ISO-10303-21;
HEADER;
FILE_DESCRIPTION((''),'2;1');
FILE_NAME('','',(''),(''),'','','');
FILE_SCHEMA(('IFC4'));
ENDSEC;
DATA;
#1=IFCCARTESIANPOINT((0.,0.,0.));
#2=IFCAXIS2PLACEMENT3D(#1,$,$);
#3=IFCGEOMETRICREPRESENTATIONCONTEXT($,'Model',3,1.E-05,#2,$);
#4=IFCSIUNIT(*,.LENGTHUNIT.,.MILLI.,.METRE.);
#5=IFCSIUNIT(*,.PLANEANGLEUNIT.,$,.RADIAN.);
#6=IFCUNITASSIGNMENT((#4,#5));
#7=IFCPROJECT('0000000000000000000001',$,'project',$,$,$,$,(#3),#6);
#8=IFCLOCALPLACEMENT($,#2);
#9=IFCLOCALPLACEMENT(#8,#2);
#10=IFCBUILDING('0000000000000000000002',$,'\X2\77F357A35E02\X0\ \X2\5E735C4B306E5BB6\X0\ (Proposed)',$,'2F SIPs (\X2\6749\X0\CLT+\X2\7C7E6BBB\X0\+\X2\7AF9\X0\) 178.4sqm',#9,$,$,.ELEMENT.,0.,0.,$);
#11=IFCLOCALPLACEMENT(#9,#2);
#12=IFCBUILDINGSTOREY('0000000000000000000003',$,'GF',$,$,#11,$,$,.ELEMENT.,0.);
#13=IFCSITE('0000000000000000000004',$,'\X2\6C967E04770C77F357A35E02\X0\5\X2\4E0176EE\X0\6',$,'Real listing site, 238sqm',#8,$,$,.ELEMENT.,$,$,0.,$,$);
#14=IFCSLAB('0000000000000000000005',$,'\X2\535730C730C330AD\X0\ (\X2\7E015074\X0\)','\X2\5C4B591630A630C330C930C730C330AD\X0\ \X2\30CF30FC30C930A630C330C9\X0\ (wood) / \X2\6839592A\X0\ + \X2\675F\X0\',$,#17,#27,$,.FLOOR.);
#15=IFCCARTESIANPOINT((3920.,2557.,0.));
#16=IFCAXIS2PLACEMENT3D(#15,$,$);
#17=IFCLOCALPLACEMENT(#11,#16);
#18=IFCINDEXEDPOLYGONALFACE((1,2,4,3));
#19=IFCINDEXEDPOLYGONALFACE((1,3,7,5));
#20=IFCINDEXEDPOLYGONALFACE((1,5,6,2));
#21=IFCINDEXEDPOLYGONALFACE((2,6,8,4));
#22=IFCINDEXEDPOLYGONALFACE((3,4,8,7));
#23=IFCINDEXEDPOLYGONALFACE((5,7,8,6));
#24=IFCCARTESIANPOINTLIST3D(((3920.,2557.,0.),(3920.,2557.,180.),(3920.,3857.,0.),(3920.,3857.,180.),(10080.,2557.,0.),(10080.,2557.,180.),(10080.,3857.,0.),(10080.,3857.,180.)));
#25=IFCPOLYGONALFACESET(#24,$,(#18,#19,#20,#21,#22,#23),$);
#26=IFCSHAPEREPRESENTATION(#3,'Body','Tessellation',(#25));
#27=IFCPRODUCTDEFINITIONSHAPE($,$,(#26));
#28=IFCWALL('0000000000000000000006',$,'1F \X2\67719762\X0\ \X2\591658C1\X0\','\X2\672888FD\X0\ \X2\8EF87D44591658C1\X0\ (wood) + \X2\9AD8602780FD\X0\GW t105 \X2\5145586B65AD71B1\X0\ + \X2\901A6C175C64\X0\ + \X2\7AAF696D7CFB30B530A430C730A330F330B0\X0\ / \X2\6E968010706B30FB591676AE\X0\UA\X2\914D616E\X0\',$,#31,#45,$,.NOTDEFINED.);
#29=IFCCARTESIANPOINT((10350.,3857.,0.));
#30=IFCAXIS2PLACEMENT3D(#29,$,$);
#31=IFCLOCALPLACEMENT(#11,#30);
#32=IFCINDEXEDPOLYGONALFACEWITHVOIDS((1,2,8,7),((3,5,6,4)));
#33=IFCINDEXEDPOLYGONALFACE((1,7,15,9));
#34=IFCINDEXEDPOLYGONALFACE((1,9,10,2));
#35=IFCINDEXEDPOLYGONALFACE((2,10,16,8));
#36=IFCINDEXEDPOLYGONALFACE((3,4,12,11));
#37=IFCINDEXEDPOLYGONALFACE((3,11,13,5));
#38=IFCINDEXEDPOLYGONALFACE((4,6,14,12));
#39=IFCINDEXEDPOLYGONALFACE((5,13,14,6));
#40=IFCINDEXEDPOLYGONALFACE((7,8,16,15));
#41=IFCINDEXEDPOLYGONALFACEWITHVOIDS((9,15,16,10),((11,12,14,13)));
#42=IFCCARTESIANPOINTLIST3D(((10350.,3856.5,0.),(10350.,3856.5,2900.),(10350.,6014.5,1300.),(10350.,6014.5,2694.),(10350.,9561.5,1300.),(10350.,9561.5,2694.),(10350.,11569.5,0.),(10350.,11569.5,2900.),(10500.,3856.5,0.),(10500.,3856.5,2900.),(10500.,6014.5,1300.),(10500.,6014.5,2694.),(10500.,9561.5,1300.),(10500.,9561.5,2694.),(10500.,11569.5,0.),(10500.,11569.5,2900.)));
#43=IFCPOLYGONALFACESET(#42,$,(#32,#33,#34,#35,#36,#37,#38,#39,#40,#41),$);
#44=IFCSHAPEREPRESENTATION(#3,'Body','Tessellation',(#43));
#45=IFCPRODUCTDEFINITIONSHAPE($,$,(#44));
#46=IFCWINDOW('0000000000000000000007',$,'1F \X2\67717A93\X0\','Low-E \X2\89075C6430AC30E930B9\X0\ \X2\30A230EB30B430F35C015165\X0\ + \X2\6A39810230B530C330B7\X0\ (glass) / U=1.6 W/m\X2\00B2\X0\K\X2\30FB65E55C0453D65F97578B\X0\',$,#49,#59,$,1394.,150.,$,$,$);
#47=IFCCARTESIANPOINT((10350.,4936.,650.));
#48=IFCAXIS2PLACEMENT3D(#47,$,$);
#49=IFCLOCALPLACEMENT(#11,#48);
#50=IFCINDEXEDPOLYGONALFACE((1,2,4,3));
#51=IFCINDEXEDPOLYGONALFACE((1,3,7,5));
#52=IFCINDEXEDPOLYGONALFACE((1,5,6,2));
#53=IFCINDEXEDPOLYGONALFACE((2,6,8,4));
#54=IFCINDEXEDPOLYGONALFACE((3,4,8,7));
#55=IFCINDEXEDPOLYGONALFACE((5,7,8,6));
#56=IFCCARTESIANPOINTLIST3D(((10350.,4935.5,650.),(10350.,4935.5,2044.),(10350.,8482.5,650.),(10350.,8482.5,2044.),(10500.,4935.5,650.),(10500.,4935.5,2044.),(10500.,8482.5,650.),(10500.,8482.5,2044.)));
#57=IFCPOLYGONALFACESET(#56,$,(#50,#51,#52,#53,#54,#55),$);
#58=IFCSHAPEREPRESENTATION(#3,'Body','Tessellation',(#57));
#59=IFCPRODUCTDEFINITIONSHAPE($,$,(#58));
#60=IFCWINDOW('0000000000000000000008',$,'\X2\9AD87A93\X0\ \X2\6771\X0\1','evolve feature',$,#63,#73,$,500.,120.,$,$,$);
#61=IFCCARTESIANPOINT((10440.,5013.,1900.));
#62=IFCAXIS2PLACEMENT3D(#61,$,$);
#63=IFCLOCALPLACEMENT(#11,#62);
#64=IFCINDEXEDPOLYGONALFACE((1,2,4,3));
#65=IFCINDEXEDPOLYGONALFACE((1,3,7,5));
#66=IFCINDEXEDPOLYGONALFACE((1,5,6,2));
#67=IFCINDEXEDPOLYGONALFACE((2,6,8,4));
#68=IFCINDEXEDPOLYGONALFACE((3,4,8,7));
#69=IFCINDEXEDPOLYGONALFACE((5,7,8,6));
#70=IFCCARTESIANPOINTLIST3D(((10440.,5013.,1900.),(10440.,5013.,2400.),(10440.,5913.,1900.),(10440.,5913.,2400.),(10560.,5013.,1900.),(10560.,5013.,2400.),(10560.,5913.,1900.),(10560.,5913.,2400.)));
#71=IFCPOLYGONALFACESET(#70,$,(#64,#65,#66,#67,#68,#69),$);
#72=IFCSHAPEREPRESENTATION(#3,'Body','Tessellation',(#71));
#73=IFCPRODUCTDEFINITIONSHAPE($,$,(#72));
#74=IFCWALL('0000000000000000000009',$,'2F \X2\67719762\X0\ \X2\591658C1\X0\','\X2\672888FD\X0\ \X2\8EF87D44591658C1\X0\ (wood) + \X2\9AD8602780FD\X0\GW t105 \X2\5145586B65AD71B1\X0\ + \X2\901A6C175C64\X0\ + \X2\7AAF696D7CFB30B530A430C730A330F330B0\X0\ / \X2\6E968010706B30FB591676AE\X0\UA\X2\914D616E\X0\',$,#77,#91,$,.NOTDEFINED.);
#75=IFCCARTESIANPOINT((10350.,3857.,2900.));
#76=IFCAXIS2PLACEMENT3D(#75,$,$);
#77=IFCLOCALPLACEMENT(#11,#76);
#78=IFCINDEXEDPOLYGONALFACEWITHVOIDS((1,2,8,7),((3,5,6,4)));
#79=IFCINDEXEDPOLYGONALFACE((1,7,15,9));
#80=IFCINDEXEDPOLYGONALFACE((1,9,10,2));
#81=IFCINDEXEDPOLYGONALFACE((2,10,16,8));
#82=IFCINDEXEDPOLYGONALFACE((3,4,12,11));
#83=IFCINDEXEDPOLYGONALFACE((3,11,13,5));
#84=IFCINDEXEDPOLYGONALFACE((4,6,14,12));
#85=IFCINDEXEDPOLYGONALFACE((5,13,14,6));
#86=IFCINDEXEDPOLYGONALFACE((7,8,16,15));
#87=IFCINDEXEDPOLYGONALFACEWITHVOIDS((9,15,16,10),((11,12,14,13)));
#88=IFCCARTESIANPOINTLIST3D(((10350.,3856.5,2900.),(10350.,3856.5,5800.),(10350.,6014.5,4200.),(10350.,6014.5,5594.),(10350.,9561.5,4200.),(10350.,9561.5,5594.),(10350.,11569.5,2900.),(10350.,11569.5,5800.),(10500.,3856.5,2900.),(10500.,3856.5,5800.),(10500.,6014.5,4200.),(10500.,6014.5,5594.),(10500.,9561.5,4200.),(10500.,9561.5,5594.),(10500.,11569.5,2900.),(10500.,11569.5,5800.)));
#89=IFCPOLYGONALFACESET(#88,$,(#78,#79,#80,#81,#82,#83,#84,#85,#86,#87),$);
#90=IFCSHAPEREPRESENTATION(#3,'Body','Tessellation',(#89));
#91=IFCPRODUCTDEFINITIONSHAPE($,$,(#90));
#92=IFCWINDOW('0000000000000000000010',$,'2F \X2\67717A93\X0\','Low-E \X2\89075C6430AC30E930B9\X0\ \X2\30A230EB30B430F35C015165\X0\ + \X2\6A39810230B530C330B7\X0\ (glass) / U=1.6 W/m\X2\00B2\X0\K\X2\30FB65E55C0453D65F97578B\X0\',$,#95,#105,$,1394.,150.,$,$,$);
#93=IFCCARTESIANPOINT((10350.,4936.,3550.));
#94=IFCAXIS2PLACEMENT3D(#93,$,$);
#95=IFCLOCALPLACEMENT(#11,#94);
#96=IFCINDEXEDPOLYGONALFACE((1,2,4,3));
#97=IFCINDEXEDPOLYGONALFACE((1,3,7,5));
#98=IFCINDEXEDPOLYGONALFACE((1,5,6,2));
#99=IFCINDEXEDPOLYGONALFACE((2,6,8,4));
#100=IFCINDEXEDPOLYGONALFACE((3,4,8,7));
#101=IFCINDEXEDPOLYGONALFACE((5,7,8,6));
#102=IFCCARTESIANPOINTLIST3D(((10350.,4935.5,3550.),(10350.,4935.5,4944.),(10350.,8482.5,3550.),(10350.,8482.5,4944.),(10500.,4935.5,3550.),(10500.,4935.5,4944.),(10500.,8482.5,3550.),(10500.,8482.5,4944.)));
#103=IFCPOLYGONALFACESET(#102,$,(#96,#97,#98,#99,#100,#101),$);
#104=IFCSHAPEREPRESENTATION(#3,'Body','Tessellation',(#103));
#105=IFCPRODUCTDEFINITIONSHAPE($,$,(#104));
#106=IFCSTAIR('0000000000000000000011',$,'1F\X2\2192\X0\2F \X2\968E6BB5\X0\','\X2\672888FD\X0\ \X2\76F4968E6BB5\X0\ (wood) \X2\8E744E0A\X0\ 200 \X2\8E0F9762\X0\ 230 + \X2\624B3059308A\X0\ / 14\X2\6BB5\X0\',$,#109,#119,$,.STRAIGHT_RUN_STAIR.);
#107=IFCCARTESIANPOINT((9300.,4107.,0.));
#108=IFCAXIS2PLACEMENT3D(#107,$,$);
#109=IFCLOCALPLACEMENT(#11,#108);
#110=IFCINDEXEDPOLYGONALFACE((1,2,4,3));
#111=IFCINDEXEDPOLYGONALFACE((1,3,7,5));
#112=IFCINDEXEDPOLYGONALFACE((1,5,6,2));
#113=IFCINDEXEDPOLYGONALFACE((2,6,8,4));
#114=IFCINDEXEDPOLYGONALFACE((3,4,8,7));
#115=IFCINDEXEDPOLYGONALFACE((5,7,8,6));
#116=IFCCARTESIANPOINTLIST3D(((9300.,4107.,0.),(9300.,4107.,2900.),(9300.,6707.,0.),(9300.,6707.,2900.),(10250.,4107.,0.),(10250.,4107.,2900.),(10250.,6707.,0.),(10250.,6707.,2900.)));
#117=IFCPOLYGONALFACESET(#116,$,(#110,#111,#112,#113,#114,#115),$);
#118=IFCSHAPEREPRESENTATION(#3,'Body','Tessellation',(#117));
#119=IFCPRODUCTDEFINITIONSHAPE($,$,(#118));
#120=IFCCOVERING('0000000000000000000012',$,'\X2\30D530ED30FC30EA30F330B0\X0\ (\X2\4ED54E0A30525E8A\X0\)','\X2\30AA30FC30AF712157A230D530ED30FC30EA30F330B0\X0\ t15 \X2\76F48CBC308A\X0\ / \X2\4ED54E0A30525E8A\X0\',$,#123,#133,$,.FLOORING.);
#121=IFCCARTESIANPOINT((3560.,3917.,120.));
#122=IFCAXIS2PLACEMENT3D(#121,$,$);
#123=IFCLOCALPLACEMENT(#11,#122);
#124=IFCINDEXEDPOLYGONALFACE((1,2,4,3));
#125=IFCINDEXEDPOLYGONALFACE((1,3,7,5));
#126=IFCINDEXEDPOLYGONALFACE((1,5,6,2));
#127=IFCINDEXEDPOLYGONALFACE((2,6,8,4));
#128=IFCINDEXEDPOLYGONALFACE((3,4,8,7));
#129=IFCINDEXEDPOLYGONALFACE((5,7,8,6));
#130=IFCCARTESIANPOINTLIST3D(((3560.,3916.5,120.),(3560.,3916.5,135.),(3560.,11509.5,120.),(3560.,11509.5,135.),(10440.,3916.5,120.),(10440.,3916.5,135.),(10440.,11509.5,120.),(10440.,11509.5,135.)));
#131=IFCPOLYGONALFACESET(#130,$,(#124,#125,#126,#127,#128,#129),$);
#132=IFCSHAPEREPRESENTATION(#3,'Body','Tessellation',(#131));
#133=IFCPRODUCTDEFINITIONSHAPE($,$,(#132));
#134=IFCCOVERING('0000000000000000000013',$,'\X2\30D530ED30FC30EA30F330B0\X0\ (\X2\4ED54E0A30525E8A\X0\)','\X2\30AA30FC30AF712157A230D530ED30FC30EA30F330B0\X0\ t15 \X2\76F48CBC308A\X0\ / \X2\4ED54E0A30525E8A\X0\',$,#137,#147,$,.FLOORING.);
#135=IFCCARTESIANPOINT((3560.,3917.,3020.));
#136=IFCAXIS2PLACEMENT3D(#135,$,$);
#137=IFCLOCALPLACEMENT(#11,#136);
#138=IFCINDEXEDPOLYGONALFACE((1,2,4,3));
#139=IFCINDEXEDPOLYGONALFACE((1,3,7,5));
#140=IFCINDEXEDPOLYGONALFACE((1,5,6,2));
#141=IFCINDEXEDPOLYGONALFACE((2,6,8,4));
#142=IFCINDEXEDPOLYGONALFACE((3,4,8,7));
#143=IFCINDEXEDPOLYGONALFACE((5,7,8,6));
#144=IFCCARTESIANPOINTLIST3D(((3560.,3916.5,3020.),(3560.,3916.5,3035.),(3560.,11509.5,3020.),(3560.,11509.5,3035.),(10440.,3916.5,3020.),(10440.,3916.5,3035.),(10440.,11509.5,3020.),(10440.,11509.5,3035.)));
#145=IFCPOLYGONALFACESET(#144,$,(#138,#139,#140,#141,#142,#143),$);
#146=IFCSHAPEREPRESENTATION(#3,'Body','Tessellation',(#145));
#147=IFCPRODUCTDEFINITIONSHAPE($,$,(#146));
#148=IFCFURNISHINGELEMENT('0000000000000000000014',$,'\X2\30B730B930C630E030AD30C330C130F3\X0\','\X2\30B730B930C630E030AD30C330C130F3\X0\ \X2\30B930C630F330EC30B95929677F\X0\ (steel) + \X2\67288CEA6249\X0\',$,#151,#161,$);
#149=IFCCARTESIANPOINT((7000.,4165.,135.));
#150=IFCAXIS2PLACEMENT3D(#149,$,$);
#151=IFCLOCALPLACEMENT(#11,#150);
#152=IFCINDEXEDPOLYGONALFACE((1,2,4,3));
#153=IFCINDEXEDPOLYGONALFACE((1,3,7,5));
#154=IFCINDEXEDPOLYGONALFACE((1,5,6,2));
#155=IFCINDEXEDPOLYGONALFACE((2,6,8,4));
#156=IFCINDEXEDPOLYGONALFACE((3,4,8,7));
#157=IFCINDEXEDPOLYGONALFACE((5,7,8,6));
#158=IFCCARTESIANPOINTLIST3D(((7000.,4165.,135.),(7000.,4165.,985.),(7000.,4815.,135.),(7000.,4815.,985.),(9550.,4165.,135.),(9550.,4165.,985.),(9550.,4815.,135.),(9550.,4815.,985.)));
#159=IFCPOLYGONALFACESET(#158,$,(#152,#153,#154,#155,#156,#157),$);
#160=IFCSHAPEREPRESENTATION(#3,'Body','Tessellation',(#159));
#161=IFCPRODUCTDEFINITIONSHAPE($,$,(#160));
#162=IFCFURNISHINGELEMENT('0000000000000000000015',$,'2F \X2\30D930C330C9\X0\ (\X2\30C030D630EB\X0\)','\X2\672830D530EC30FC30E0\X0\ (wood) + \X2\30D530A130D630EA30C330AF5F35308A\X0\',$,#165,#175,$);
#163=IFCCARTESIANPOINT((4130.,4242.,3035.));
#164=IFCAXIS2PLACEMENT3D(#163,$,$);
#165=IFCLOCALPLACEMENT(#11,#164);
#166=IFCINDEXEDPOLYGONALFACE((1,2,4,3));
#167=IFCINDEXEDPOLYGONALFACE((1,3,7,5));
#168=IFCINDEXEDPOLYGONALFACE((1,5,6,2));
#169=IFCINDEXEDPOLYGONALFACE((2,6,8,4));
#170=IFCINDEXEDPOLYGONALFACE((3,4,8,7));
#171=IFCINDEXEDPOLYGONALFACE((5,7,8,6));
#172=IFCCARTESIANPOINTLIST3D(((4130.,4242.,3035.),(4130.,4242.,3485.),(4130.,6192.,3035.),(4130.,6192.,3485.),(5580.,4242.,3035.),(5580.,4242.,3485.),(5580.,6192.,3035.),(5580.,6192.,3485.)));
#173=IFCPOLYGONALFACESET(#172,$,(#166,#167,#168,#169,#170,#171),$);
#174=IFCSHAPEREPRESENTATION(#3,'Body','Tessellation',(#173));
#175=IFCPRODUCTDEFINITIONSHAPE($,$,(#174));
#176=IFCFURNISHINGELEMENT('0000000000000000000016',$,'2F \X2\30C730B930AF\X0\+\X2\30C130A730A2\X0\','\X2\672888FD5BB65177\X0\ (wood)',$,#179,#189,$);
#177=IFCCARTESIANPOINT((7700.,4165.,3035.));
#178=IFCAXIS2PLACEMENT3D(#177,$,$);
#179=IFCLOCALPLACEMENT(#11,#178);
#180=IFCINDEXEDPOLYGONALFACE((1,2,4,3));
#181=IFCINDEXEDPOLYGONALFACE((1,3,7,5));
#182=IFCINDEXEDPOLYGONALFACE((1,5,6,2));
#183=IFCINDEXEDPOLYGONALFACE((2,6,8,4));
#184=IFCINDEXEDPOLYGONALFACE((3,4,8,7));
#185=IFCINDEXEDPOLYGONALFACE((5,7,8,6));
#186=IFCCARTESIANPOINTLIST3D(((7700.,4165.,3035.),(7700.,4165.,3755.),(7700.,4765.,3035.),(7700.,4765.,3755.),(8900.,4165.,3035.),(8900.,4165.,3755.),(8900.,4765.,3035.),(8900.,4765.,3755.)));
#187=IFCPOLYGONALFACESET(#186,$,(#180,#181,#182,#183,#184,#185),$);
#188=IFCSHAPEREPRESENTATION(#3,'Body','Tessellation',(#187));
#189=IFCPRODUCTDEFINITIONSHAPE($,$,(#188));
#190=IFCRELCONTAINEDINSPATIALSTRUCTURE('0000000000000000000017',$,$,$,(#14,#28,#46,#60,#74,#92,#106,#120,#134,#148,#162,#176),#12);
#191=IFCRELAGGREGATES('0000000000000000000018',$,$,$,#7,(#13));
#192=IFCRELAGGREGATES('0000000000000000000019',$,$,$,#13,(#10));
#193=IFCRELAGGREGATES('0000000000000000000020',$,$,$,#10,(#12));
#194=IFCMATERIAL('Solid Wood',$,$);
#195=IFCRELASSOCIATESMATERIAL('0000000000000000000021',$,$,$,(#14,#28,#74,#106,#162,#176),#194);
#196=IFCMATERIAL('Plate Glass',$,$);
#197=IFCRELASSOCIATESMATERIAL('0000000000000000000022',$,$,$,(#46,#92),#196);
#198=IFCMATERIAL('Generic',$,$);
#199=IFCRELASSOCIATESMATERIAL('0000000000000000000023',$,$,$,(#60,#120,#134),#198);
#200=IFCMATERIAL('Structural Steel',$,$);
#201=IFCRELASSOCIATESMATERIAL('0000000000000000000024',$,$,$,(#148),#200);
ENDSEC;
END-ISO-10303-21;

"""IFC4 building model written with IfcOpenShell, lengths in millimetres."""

from ifc_helpers import new_model, si_unit, frame, frame_2d, origin, place, context, project, spatial, rectangle, extrude, material, element, fill, save


model = new_model("IFC4")

# Units and contexts
model_context = context("Model", 3, precision=1e-05, world=origin())
ifc_project = project(units=[si_unit("LENGTHUNIT", "METRE", prefix="MILLI"), si_unit("PLANEANGLEUNIT", "RADIAN")], contexts=[model_context])

# Site, building, storey
site_placement = place(None, origin())
site = spatial("IfcSite", under=ifc_project, at=site_placement, Name="沖縄県石垣市5丁目6", ObjectType="Real listing site, 238sqm", CompositionType="ELEMENT", RefElevation=0.0)
building_placement = place(site_placement, origin())
building = spatial("IfcBuilding", under=site, at=building_placement, Name="石垣市 平屋の家 (Proposed)", ObjectType="2F SIPs (杉CLT+籾殻+竹) 178.4sqm", CompositionType="ELEMENT", ElevationOfRefHeight=0.0, ElevationOfTerrain=0.0)
storey_placement = place(building_placement, origin())
storey = spatial("IfcBuildingStorey", under=building, at=storey_placement, Name="GF", CompositionType="ELEMENT", Elevation=0.0)

# Slab
ifc_material_1 = material(Name="Solid Wood")
slab_placement = place(storey_placement, frame((3920.0, 2557.0, 0.0)))
element("IfcSlab", 1, at=slab_placement, inside=storey, material=ifc_material_1, Name="南デッキ (縁側)", Description="屋外ウッドデッキ ハードウッド (wood) / 根太 + 束", PredefinedType="FLOOR", context=model_context, shape_type="SweptSolid", body=[
    extrude(rectangle(XDim=6160.0, YDim=1300.0, at=frame_2d((3080.0, 650.0))), frame((3920.0, 2557.0, 0.0)), (0.0, 0.0, 1.0), 180.0),
])

# Wall, openings, windows
wall_1_placement = place(storey_placement, frame((10350.0, 3857.0, 0.0)))
wall_1 = element("IfcWall", 2, at=wall_1_placement, inside=storey, material=ifc_material_1, Name="1F 東面 外壁", Description="木製 軸組外壁 (wood) + 高性能GW t105 充填断熱 + 通気層 + 窯業系サイディング / 準耐火・外皮UA配慮", PredefinedType="NOTDEFINED", context=model_context, shape_type="SweptSolid", body=[
    extrude(rectangle(XDim=150.0, YDim=7713.0, at=frame_2d((75.0, 3856.0))), frame((10350.0, 3857.0, 0.0)), (0.0, 0.0, 1.0), 2900.0),
])
opening_1_placement = place(storey_placement, frame((10350.0, 4936.0, 650.0)))
opening_1 = element("IfcOpeningElement", 3, at=opening_1_placement, cuts=wall_1, PredefinedType="NOTDEFINED", context=model_context, shape_type="SweptSolid", body=[
    extrude(rectangle(XDim=150.0, YDim=3547.0, at=frame_2d((75.0, 1773.0))), frame((10350.0, 4936.0, 650.0)), (0.0, 0.0, 1.0), 1394.0),
])
opening_2_placement = place(storey_placement, frame((10440.0, 5013.0, 1900.0)))
opening_2 = element("IfcOpeningElement", 4, at=opening_2_placement, cuts=wall_1, PredefinedType="NOTDEFINED", context=model_context, shape_type="SweptSolid", body=[
    extrude(rectangle(XDim=120.0, YDim=900.0, at=frame_2d((60.0, 450.0))), frame((10440.0, 5013.0, 1900.0)), (0.0, 0.0, 1.0), 500.0),
])
ifc_material_2 = material(Name="Plate Glass")
window_1_placement = place(storey_placement, frame((10350.0, 4936.0, 650.0)))
window_1 = element("IfcWindow", 5, at=window_1_placement, inside=storey, material=ifc_material_2, Name="1F 東窓", Description="Low-E 複層ガラス アルゴン封入 + 樹脂サッシ (glass) / U=1.6 W/m²K・日射取得型", OverallHeight=1394.0, OverallWidth=150.0, context=model_context, shape_type="SweptSolid", body=[
    extrude(rectangle(XDim=150.0, YDim=3547.0, at=frame_2d((75.0, 1773.0))), frame((10350.0, 4936.0, 650.0)), (0.0, 0.0, 1.0), 1394.0),
])
fill(opening_1, window_1)
ifc_material_3 = material(Name="Generic")
window_2_placement = place(storey_placement, frame((10440.0, 5013.0, 1900.0)))
window_2 = element("IfcWindow", 6, at=window_2_placement, inside=storey, material=ifc_material_3, Name="高窓 東1", Description="evolve feature", OverallHeight=500.0, OverallWidth=120.0, context=model_context, shape_type="SweptSolid", body=[
    extrude(rectangle(XDim=120.0, YDim=900.0, at=frame_2d((60.0, 450.0))), frame((10440.0, 5013.0, 1900.0)), (0.0, 0.0, 1.0), 500.0),
])
fill(opening_2, window_2)

# Wall, opening, window
wall_2_placement = place(storey_placement, frame((10350.0, 3857.0, 2900.0)))
wall_2 = element("IfcWall", 7, at=wall_2_placement, inside=storey, material=ifc_material_1, Name="2F 東面 外壁", Description="木製 軸組外壁 (wood) + 高性能GW t105 充填断熱 + 通気層 + 窯業系サイディング / 準耐火・外皮UA配慮", PredefinedType="NOTDEFINED", context=model_context, shape_type="SweptSolid", body=[
    extrude(rectangle(XDim=150.0, YDim=7713.0, at=frame_2d((75.0, 3856.0))), frame((10350.0, 3857.0, 2900.0)), (0.0, 0.0, 1.0), 2900.0),
])
opening_3_placement = place(storey_placement, frame((10350.0, 4936.0, 3550.0)))
opening_3 = element("IfcOpeningElement", 8, at=opening_3_placement, cuts=wall_2, PredefinedType="NOTDEFINED", context=model_context, shape_type="SweptSolid", body=[
    extrude(rectangle(XDim=150.0, YDim=3547.0, at=frame_2d((75.0, 1773.0))), frame((10350.0, 4936.0, 3550.0)), (0.0, 0.0, 1.0), 1394.0),
])
window_3_placement = place(storey_placement, frame((10350.0, 4936.0, 3550.0)))
window_3 = element("IfcWindow", 9, at=window_3_placement, inside=storey, material=ifc_material_2, Name="2F 東窓", Description="Low-E 複層ガラス アルゴン封入 + 樹脂サッシ (glass) / U=1.6 W/m²K・日射取得型", OverallHeight=1394.0, OverallWidth=150.0, context=model_context, shape_type="SweptSolid", body=[
    extrude(rectangle(XDim=150.0, YDim=3547.0, at=frame_2d((75.0, 1773.0))), frame((10350.0, 4936.0, 3550.0)), (0.0, 0.0, 1.0), 1394.0),
])
fill(opening_3, window_3)

# Stair
stair_placement = place(storey_placement, frame((9300.0, 4107.0, 0.0)))
element("IfcStair", 10, at=stair_placement, inside=storey, material=ifc_material_1, Name="1F→2F 階段", Description="木製 直階段 (wood) 蹴上 200 踏面 230 + 手すり / 14段", PredefinedType="STRAIGHT_RUN_STAIR", context=model_context, shape_type="SweptSolid", body=[
    extrude(rectangle(XDim=950.0, YDim=2600.0, at=frame_2d((475.0, 1300.0))), frame((9300.0, 4107.0, 0.0)), (0.0, 0.0, 1.0), 2900.0),
])

# Coverings
covering_1_placement = place(storey_placement, frame((3560.0, 3917.0, 120.0)))
element("IfcCovering", 11, at=covering_1_placement, inside=storey, material=ifc_material_3, Name="フローリング (仕上げ床)", Description="オーク無垢フローリング t15 直貼り / 仕上げ床", PredefinedType="FLOORING", context=model_context, shape_type="SweptSolid", body=[
    extrude(rectangle(XDim=6880.0, YDim=7593.0, at=frame_2d((3440.0, 3796.0))), frame((3560.0, 3917.0, 120.0)), (0.0, 0.0, 1.0), 15.0),
])
covering_2_placement = place(storey_placement, frame((3560.0, 3917.0, 3020.0)))
element("IfcCovering", 12, at=covering_2_placement, inside=storey, material=ifc_material_3, Name="フローリング (仕上げ床)", Description="オーク無垢フローリング t15 直貼り / 仕上げ床", PredefinedType="FLOORING", context=model_context, shape_type="SweptSolid", body=[
    extrude(rectangle(XDim=6880.0, YDim=7593.0, at=frame_2d((3440.0, 3796.0))), frame((3560.0, 3917.0, 3020.0)), (0.0, 0.0, 1.0), 15.0),
])

# Furnishing elements
ifc_material_4 = material(Name="Structural Steel")
furnishing_1_placement = place(storey_placement, frame((7000.0, 4165.0, 135.0)))
element("IfcFurnishingElement", 13, at=furnishing_1_placement, inside=storey, material=ifc_material_4, Name="システムキッチン", Description="システムキッチン ステンレス天板 (steel) + 木質扉", context=model_context, shape_type="SweptSolid", body=[
    extrude(rectangle(XDim=2550.0, YDim=650.0, at=frame_2d((1275.0, 325.0))), frame((7000.0, 4165.0, 135.0)), (0.0, 0.0, 1.0), 850.0),
])
furnishing_2_placement = place(storey_placement, frame((4130.0, 4242.0, 3035.0)))
element("IfcFurnishingElement", 14, at=furnishing_2_placement, inside=storey, material=ifc_material_1, Name="2F ベッド (ダブル)", Description="木フレーム (wood) + ファブリック張り", context=model_context, shape_type="SweptSolid", body=[
    extrude(rectangle(XDim=1450.0, YDim=1950.0, at=frame_2d((725.0, 975.0))), frame((4130.0, 4242.0, 3035.0)), (0.0, 0.0, 1.0), 450.0),
])
furnishing_3_placement = place(storey_placement, frame((7700.0, 4165.0, 3035.0)))
element("IfcFurnishingElement", 15, at=furnishing_3_placement, inside=storey, material=ifc_material_1, Name="2F デスク+チェア", Description="木製家具 (wood)", context=model_context, shape_type="SweptSolid", body=[
    extrude(rectangle(XDim=1200.0, YDim=600.0, at=frame_2d((600.0, 300.0))), frame((7700.0, 4165.0, 3035.0)), (0.0, 0.0, 1.0), 720.0),
])

save(model, "model.ifc")
